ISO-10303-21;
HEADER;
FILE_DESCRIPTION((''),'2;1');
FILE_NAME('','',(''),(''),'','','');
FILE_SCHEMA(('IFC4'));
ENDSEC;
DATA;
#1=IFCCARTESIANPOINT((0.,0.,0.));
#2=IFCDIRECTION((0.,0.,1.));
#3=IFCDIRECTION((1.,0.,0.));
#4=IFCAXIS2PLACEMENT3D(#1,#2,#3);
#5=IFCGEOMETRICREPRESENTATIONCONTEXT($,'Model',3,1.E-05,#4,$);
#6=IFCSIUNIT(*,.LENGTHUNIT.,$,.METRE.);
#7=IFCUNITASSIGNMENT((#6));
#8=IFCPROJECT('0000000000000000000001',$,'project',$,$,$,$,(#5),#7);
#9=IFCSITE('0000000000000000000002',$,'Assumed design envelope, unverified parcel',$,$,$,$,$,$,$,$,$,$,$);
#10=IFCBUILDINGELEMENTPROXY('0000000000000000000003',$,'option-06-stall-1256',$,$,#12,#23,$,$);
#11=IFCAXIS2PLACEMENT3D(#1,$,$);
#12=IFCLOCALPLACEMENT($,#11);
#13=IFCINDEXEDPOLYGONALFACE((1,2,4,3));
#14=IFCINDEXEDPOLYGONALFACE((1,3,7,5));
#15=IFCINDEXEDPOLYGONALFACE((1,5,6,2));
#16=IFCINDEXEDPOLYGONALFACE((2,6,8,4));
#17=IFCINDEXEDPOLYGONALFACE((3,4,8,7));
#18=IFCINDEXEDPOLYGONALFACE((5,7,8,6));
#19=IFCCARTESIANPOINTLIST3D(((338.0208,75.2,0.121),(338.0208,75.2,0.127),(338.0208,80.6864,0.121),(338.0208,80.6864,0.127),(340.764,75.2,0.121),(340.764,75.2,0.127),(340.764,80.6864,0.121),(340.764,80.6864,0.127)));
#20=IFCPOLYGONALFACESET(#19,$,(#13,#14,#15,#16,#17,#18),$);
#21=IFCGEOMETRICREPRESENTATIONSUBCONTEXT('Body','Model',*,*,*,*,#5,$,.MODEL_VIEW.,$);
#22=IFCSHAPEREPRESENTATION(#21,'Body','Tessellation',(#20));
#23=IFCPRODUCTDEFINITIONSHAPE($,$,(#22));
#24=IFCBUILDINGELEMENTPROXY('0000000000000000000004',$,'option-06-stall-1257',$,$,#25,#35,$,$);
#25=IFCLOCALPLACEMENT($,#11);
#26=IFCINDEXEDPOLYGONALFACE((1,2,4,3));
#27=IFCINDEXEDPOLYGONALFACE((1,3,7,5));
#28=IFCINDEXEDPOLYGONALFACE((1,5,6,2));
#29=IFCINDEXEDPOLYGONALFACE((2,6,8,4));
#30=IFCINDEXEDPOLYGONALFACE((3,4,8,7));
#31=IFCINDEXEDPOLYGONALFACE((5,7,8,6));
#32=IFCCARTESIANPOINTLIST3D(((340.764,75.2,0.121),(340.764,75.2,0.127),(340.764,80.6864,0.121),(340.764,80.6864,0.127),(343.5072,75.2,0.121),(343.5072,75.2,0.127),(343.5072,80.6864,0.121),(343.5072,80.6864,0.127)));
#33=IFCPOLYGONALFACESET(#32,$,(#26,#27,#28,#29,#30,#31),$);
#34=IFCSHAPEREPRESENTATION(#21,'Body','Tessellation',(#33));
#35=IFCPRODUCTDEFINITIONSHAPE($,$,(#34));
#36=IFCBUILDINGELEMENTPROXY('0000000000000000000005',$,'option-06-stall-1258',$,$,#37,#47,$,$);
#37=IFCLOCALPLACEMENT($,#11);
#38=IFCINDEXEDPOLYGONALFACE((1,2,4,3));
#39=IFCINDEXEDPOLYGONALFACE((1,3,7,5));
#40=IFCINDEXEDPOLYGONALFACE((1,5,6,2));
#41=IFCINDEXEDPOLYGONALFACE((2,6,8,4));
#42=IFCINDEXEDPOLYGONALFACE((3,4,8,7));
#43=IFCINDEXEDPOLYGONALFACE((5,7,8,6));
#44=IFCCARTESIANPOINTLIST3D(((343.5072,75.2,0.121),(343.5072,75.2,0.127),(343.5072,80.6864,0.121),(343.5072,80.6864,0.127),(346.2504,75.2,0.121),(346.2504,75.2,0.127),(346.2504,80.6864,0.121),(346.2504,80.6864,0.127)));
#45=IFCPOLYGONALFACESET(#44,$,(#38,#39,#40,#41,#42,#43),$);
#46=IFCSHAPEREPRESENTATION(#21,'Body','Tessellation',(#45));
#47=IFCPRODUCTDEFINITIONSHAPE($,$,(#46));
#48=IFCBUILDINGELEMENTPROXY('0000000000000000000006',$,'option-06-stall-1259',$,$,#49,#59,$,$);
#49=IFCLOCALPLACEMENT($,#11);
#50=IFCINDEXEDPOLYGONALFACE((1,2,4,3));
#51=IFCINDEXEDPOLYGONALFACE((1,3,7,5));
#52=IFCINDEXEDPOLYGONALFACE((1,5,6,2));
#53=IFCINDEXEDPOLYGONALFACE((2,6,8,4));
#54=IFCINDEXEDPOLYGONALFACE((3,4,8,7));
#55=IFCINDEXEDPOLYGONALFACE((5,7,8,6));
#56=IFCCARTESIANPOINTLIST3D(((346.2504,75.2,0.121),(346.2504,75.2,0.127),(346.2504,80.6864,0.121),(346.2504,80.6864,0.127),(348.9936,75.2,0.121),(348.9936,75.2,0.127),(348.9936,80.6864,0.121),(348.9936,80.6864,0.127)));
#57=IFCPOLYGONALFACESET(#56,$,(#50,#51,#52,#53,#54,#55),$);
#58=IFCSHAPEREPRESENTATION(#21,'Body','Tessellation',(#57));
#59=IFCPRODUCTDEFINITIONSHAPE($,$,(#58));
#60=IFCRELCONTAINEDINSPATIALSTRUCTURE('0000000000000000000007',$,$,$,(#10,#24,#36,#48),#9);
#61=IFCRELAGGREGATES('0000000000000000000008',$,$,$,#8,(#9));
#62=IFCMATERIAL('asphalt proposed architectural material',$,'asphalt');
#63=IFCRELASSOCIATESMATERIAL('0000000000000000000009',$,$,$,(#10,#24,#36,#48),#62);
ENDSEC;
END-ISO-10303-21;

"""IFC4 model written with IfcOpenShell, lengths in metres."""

from ifc_helpers import new_model, si_unit, frame, origin_with_axes, place, context, subcontext, project, spatial, rectangle, extrude, material, element, save


model = new_model("IFC4")

# Units and contexts
model_context = context("Model", 3, precision=1e-05, world=origin_with_axes())
body_context = subcontext(model_context, "Body", "Model", "MODEL_VIEW")
ifc_project = project(units=[si_unit("LENGTHUNIT", "METRE")], contexts=[model_context])

# Site
site = spatial("IfcSite", under=ifc_project, Name="Assumed design envelope, unverified parcel")

# Building element proxies
ifc_material_1 = material(Name="asphalt proposed architectural material", Category="asphalt")
for number, where, z_axis, x_axis, name in (
    (1, (339.3924, 77.9432, 0.121), (0.0, 0.0, 1.0), (1.0, 0.0, 0.0), "option-06-stall-1256"),
    (2, (342.1356, 77.9432, 0.121), (0.0, 0.0, 1.0), (1.0, 0.0, 0.0), "option-06-stall-1257"),
    (3, (344.8788, 77.9432, 0.121), (0.0, 0.0, 1.0), (1.0, 0.0, 0.0), "option-06-stall-1258"),
    (4, (347.622, 77.9432, 0.121), (0.0, 0.0, 1.0), (1.0, 0.0, 0.0), "option-06-stall-1259"),
):
    element("IfcBuildingElementProxy", number, at=place(None, frame(where, z_axis=z_axis, x_axis=x_axis)), inside=site, material=ifc_material_1, Name=name, context=body_context, shape_type="SweptSolid", body=[
        extrude(rectangle(XDim=2.7432, YDim=5.4864), origin_with_axes(), (0.0, 0.0, 1.0), 0.006),
    ])

save(model, "model.ifc")
